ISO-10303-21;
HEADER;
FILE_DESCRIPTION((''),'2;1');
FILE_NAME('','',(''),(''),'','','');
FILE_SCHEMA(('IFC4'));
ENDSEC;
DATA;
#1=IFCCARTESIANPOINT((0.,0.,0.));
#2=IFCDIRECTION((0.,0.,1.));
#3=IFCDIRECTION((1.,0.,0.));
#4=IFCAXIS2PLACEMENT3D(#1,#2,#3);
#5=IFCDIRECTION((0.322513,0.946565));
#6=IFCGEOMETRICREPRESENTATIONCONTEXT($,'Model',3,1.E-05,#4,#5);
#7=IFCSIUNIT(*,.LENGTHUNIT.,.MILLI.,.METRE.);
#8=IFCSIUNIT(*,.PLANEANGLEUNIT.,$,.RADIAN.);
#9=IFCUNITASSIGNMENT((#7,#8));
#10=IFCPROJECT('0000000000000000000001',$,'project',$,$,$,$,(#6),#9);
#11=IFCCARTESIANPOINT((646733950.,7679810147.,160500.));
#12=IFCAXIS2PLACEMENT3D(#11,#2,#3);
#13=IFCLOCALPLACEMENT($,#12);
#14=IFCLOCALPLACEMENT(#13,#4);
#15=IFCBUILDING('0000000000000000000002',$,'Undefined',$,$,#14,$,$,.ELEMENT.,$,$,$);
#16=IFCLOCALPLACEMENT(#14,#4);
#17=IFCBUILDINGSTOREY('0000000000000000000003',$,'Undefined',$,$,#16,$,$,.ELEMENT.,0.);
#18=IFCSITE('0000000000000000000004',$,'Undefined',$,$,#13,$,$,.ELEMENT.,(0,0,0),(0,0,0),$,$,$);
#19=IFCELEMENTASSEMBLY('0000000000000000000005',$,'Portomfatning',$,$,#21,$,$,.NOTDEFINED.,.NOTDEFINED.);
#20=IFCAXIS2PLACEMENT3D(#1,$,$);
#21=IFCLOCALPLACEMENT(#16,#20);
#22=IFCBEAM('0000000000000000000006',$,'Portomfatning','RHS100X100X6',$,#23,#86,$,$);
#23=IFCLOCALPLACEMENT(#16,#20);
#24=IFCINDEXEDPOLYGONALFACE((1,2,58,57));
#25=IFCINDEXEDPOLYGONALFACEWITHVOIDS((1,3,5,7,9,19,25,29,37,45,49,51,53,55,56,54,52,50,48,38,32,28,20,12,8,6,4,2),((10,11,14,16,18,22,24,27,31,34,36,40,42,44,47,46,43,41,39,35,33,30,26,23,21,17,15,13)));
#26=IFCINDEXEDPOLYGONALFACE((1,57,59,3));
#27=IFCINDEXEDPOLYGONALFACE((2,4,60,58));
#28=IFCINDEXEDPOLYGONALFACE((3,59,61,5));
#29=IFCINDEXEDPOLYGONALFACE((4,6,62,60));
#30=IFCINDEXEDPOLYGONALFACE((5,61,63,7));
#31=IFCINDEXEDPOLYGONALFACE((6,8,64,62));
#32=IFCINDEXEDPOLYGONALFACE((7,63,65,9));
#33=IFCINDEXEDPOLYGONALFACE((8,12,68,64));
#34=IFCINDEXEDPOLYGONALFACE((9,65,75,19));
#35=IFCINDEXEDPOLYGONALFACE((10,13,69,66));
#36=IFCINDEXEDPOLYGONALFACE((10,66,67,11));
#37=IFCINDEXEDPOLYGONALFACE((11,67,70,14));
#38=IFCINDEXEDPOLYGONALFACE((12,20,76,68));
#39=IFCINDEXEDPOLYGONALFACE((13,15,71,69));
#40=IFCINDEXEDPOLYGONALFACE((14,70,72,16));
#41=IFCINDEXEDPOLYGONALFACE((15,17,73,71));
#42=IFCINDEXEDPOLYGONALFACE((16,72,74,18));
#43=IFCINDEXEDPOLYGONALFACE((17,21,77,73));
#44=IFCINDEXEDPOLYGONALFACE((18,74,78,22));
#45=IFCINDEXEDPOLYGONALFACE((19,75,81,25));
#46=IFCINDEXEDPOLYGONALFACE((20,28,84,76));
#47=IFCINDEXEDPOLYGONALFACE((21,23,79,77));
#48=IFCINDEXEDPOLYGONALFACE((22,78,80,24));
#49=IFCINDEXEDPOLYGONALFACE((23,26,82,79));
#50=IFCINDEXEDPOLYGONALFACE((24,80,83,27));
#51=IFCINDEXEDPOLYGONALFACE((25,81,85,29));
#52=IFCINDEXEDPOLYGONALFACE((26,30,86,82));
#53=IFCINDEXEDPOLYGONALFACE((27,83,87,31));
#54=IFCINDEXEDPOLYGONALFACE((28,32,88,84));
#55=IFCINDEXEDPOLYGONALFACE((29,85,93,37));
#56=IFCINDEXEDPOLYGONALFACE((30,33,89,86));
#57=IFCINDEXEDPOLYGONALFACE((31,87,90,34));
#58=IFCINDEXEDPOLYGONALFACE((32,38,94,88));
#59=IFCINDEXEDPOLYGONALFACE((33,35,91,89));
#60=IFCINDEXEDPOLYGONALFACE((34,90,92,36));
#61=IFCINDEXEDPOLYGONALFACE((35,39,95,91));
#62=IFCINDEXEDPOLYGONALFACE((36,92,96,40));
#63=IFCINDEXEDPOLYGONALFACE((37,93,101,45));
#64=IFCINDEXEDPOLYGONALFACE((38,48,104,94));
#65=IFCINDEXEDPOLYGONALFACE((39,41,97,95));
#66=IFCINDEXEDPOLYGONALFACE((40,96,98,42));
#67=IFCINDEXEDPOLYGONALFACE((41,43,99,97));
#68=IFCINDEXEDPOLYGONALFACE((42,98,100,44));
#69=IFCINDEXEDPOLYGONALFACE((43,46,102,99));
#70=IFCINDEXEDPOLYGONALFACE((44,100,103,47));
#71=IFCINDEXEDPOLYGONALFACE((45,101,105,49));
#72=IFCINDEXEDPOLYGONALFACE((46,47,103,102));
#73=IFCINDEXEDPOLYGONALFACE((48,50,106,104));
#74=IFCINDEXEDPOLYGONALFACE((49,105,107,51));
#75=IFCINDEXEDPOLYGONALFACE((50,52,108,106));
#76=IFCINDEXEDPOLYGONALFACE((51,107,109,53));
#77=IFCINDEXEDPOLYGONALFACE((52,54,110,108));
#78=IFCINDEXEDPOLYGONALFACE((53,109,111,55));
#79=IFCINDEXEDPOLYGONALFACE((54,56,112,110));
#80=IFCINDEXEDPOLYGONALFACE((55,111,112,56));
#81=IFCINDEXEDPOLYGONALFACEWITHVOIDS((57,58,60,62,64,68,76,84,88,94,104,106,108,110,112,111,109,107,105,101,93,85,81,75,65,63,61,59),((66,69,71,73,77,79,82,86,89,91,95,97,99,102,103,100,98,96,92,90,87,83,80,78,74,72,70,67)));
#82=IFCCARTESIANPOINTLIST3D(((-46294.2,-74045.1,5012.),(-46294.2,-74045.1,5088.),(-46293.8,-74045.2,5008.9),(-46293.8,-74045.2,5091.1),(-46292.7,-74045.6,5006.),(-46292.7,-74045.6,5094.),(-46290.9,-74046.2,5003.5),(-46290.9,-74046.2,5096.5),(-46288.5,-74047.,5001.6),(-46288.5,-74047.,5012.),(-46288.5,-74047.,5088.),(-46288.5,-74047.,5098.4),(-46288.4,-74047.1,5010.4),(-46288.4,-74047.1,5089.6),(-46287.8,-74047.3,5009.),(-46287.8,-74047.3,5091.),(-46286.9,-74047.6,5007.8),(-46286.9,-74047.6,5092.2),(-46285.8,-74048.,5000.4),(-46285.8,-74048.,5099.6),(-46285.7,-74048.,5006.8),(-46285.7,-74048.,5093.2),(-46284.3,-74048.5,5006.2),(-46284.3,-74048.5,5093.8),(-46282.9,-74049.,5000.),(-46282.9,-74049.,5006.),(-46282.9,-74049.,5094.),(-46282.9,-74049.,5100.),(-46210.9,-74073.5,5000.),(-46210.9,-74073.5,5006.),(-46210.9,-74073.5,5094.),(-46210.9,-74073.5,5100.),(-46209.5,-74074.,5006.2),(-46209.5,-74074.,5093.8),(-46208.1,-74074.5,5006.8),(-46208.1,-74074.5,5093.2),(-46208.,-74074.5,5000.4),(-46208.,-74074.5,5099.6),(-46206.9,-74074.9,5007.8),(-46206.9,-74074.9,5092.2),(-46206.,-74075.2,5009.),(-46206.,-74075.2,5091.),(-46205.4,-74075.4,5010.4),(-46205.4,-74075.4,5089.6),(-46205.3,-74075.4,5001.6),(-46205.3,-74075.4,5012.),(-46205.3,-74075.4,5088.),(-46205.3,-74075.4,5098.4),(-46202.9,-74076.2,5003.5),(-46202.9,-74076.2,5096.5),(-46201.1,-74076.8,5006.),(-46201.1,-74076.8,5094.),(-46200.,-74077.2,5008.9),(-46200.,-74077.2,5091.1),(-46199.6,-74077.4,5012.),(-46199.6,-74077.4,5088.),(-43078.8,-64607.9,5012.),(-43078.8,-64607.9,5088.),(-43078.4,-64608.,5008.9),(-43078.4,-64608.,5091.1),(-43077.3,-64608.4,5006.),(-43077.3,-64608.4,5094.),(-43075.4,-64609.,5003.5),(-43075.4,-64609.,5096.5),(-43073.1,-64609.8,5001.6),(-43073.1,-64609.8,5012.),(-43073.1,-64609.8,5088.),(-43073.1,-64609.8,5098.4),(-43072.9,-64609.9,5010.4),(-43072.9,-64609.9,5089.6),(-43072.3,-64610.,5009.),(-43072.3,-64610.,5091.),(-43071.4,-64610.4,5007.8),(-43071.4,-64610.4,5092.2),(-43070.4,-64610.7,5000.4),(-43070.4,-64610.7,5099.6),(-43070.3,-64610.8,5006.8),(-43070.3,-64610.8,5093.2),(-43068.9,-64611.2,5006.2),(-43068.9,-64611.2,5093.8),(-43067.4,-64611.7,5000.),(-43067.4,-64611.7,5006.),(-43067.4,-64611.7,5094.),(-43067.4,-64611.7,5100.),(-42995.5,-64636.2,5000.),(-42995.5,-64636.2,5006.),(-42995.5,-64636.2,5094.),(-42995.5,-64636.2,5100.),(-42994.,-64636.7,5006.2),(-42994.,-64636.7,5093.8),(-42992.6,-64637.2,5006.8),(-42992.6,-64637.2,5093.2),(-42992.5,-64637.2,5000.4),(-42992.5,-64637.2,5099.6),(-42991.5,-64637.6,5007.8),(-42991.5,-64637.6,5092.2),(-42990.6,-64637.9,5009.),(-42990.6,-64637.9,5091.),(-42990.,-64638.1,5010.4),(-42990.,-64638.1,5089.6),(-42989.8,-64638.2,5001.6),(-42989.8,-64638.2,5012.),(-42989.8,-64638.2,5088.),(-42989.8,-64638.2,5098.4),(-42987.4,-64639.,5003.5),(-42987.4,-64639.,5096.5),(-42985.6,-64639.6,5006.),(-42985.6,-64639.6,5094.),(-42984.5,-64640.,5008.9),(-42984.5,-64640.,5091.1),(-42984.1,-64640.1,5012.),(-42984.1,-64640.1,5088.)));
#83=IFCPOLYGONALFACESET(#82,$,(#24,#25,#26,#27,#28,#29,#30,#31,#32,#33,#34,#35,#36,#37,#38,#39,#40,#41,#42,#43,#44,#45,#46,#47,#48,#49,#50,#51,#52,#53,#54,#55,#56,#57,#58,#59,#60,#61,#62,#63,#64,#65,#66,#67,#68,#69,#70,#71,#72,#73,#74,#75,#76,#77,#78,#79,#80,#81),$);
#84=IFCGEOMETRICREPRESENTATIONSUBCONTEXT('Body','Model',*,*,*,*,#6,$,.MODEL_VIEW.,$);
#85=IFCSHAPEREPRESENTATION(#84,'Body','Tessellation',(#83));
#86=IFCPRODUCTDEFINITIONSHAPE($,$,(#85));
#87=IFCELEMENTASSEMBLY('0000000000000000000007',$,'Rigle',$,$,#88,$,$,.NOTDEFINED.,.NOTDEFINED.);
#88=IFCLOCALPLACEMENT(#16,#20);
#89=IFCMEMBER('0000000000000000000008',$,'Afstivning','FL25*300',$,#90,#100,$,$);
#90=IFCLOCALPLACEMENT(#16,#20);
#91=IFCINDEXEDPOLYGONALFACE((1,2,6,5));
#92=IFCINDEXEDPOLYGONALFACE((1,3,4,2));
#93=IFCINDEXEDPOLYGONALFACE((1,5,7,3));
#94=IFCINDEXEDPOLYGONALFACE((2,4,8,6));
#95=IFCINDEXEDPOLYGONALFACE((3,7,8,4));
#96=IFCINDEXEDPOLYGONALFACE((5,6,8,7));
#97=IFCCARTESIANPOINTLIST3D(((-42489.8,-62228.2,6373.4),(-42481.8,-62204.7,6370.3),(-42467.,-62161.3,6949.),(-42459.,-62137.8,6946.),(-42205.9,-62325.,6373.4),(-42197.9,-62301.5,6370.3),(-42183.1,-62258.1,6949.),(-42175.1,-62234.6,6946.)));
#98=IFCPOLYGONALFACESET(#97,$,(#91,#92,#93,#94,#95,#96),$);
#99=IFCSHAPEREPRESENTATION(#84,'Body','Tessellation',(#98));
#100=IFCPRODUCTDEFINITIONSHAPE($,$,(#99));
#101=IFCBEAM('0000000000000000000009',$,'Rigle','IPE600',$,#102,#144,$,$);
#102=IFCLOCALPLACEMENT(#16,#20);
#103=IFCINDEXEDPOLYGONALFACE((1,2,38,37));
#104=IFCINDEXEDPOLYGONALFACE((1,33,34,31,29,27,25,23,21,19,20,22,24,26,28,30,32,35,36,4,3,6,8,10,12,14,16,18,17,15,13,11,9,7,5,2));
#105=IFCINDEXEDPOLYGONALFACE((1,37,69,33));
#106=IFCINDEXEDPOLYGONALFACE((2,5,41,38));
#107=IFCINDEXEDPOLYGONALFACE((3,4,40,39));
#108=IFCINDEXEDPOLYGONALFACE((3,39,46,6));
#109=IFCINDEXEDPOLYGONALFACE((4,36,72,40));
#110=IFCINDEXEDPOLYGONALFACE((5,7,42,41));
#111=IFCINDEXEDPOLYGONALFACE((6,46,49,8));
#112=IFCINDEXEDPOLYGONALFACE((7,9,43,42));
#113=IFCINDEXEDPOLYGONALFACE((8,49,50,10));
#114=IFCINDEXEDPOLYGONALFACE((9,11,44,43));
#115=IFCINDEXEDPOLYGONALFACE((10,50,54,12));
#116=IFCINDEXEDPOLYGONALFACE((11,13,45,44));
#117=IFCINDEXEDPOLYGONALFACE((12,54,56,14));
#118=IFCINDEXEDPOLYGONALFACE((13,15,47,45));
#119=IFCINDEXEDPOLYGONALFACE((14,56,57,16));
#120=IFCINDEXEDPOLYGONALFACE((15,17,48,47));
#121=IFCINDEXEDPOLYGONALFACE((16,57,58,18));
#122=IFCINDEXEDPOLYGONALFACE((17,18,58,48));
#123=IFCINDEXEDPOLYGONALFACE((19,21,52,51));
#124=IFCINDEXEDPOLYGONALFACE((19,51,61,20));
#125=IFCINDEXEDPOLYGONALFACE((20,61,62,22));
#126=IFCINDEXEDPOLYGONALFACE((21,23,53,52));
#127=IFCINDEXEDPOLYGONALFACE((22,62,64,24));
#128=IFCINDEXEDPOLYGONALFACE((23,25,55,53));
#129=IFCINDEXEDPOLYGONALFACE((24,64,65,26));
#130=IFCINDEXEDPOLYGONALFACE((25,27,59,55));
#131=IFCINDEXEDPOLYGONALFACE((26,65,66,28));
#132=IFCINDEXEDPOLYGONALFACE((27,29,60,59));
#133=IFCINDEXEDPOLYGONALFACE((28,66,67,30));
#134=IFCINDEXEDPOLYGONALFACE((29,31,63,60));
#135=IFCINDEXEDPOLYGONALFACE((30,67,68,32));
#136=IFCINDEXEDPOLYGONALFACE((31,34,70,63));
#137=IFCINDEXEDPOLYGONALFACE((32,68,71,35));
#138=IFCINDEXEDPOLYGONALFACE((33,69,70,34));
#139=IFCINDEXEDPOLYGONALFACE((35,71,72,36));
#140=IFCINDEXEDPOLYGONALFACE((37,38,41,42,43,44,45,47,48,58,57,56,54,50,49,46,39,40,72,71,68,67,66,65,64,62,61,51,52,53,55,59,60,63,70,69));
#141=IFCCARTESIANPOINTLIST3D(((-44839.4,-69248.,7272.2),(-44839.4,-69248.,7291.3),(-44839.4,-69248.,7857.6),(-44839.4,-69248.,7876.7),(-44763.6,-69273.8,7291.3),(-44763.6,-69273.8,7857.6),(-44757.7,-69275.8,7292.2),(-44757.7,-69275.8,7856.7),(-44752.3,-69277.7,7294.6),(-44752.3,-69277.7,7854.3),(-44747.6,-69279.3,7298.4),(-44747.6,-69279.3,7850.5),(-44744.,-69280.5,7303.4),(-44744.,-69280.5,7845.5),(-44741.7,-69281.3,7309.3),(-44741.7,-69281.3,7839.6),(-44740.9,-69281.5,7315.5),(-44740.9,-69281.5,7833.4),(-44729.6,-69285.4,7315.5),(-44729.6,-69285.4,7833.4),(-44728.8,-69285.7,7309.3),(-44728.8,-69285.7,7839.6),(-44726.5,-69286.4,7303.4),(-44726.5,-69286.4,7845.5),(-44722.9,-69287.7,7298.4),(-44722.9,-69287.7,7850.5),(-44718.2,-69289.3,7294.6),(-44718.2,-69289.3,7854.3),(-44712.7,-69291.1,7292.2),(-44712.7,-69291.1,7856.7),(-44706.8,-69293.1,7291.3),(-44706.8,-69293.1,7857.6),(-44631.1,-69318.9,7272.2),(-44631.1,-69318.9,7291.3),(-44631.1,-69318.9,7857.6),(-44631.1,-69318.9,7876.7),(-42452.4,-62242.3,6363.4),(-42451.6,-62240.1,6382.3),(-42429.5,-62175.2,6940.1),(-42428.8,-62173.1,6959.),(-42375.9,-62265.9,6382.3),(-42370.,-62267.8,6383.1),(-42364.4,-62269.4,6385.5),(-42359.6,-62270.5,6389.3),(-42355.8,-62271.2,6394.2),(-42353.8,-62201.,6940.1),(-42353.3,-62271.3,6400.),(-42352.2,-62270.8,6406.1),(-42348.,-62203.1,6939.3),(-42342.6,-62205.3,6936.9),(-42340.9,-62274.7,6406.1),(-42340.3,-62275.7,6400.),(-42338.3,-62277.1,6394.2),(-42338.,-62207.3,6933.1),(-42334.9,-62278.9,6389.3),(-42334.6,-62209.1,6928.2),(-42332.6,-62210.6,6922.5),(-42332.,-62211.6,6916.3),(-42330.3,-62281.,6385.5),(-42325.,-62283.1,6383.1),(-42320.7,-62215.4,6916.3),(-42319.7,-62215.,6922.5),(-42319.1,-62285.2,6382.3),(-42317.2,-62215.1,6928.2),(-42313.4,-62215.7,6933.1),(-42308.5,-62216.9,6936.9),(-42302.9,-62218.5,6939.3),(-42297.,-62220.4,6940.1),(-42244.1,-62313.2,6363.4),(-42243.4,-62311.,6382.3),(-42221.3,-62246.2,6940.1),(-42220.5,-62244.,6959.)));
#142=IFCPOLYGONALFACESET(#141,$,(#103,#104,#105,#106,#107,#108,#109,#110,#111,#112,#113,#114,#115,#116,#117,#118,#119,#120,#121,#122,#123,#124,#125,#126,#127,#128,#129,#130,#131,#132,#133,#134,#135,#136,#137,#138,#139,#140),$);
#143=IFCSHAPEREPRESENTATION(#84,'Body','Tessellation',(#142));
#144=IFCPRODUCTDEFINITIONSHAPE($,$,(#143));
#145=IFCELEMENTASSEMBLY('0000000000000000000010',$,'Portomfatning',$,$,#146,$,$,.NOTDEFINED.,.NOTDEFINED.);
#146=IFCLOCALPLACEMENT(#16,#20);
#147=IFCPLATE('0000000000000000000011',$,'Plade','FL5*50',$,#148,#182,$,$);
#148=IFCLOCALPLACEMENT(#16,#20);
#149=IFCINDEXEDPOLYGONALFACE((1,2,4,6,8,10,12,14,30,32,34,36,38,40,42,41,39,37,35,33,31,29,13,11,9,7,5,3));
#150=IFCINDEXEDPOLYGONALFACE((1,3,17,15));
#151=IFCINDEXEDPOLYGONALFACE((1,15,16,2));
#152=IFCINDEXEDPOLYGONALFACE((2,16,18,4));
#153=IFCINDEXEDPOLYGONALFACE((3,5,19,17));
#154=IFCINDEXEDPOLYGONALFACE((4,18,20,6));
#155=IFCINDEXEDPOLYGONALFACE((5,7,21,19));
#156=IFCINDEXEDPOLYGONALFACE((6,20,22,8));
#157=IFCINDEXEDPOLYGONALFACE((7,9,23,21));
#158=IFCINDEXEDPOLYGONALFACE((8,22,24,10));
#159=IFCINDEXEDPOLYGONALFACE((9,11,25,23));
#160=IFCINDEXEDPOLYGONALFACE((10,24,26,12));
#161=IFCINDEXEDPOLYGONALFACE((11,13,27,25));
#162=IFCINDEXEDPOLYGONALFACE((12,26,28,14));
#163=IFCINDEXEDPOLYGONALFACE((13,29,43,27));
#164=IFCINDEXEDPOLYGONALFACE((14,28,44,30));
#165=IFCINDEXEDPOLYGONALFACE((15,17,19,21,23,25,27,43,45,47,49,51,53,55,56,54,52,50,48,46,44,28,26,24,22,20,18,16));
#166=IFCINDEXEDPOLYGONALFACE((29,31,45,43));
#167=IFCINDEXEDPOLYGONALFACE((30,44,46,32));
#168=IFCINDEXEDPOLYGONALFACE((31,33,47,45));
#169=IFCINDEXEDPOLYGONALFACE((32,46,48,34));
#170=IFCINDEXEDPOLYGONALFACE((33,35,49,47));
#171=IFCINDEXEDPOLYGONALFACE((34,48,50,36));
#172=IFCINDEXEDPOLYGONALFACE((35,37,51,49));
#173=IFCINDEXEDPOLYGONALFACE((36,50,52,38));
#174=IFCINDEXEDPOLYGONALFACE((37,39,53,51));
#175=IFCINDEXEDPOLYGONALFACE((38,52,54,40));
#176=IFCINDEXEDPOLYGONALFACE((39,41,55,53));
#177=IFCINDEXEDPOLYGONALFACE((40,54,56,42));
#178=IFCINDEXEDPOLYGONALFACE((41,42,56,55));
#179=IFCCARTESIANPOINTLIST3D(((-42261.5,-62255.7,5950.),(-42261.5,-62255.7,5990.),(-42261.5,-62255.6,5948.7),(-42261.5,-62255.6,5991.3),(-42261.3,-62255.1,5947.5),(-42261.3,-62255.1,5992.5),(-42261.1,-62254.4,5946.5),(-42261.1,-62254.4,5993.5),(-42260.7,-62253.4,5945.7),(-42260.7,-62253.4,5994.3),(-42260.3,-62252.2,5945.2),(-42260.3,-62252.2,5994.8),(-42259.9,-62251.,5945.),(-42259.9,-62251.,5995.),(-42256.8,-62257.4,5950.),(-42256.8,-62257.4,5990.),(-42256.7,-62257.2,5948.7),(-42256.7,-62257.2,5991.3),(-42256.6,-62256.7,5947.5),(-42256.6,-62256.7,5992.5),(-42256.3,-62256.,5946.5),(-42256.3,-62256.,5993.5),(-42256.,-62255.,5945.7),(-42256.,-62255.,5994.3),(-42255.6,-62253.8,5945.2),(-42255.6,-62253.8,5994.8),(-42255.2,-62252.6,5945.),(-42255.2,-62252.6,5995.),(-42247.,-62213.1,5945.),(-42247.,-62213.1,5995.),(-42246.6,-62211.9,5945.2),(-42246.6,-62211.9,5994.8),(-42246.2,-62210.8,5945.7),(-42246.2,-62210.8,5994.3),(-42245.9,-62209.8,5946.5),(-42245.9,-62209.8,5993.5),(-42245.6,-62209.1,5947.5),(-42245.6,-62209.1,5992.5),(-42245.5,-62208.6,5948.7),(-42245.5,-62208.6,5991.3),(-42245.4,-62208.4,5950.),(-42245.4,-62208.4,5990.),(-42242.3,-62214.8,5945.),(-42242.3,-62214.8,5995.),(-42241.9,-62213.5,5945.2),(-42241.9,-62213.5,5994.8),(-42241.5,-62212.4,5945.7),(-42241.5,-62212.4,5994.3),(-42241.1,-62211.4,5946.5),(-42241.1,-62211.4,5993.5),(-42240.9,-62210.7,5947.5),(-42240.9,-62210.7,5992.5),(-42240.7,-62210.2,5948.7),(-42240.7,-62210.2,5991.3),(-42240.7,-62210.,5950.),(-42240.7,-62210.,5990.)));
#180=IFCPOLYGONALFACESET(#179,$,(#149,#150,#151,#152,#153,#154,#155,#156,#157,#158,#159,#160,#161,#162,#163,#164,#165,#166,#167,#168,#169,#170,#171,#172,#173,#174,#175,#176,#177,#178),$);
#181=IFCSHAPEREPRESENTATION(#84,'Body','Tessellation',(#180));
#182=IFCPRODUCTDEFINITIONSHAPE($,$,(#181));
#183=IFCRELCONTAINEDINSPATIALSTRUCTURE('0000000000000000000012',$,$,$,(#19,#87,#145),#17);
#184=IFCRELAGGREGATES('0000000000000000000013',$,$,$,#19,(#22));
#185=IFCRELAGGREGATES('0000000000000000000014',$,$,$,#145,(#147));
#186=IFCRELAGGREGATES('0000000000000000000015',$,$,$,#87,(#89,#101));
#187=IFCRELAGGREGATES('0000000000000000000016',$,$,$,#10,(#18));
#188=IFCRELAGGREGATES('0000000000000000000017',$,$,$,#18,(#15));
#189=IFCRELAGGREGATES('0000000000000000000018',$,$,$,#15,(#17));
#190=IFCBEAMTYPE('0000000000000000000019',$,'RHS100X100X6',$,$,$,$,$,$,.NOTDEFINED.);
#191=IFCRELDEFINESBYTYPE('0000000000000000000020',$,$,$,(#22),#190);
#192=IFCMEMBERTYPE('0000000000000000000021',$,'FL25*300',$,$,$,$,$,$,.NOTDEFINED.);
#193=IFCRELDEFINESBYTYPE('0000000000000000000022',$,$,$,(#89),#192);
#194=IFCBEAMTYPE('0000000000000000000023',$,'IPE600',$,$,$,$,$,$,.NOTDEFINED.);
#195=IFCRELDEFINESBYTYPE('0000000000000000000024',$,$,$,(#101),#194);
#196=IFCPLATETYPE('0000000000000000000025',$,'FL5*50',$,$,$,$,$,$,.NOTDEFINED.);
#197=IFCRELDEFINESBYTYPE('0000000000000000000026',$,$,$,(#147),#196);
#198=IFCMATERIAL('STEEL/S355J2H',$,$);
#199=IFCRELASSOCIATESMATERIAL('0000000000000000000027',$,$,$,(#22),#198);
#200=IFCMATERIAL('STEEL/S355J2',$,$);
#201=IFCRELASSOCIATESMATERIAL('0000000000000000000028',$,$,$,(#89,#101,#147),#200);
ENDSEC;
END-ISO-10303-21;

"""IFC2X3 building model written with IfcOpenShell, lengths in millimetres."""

from ifc_helpers import new_model, si_unit, direction, frame, frame_2d, origin_with_axes, origin_2d_with_axis, place, context, subcontext, project, spatial, polyline, circle_curve, parameter, trimmed, segment, composite_curve, rectangle, hollow_rectangle, i_section, outline, extrude, clip, halfspace, material, type_object, element, aggregate, save


model = new_model("IFC2X3")

# Units and contexts
model_context = context("Model", 3, precision=1e-05, world=origin_with_axes(), true_north=direction((0.322513, 0.946565)))
body_context = subcontext(model_context, "Body", "Model", "MODEL_VIEW")
ifc_project = project(units=[si_unit("LENGTHUNIT", "METRE", prefix="MILLI"), si_unit("PLANEANGLEUNIT", "RADIAN")], contexts=[model_context])

# Site, building, storey
site_placement = place(None, frame((646733950.0, 7679810147.0, 160500.0), z_axis=(0.0, 0.0, 1.0), x_axis=(1.0, 0.0, 0.0)))
site = spatial("IfcSite", under=ifc_project, at=site_placement, Name="Undefined", CompositionType="ELEMENT", RefLatitude=(0, 0, 0), RefLongitude=(0, 0, 0))
building_placement = place(site_placement, origin_with_axes())
building = spatial("IfcBuilding", under=site, at=building_placement, Name="Undefined", CompositionType="ELEMENT")
storey_placement = place(building_placement, origin_with_axes())
storey = spatial("IfcBuildingStorey", under=building, at=storey_placement, Name="Undefined", CompositionType="ELEMENT", Elevation=0.0)

# Element assembly, beam
assembly_1_placement = place(storey_placement, origin_with_axes())
assembly_1 = element("IfcElementAssembly", 1, at=assembly_1_placement, inside=storey, Name="Portomfatning", AssemblyPlace="NOTDEFINED", PredefinedType="NOTDEFINED")
ifc_material_1 = material(Name="STEEL/S355J2H")
beam_type_1 = type_object("IfcBeamType", Name="RHS100X100X6", PredefinedType="NOTDEFINED")
beam_1_placement = place(assembly_1_placement, frame((-43026.6, -64609.8, 5050.0), z_axis=(-0.946565, 0.322513, 0.0), x_axis=(-0.322513, -0.946565, 0.0)))
beam_1 = element("IfcBeam", 2, at=beam_1_placement, type_object=beam_type_1, material=ifc_material_1, Name="Portomfatning", Description="RHS100X100X6", context=body_context, shape_type="Clipping", body=[
    clip(clip(extrude(hollow_rectangle(XDim=100.0, YDim=100.0, WallThickness=6.0, InnerFilletRadius=6.0, OuterFilletRadius=12.0, at=origin_2d_with_axis()), frame((10046.7, 0.0, 0.0), z_axis=(-1.0, 0.0, 0.0), x_axis=(0.0, -1.0, 0.0)), (0.0, 0.0, 1.0), 10093.3), halfspace(frame((9985.0, 0.0, -50.0), z_axis=(-1.0, 0.0, 0.0), x_axis=(0.0, 1.0, 0.0)), True)), halfspace(frame((15.0, 0.0, -50.0), z_axis=(1.0, 0.0, 0.0), x_axis=(0.0, -1.0, 0.0)), True)),
])
aggregate(assembly_1, [beam_1])
ifc_material_2 = material(Name="STEEL/S355J2")

# Element assembly, member, beam
assembly_2_placement = place(storey_placement, origin_with_axes())
assembly_2 = element("IfcElementAssembly", 3, at=assembly_2_placement, inside=storey, Name="Rigle", AssemblyPlace="NOTDEFINED", PredefinedType="NOTDEFINED")
member_type_1 = type_object("IfcMemberType", Name="FL25*300", PredefinedType="NOTDEFINED")
member_1_placement = place(assembly_2_placement, frame((-42321.1, -62197.9, 6947.5), z_axis=(-0.946565, 0.322513, 0.0), x_axis=(-0.039304, -0.115357, -0.992546)))
member_1 = element("IfcMember", 4, at=member_1_placement, type_object=member_type_1, material=ifc_material_2, Name="Afstivning", Description="FL25*300", context=body_context, shape_type="SweptSolid", body=[
    extrude(rectangle(XDim=25.0, YDim=300.0, at=origin_2d_with_axis()), frame((580.0, 0.0, 0.0), z_axis=(-1.0, 0.0, 0.0), x_axis=(0.0, -1.0, 0.0)), (0.0, 0.0, 1.0), 580.0),
])
beam_type_2 = type_object("IfcBeamType", Name="IPE600", PredefinedType="NOTDEFINED")
beam_2_placement = place(assembly_2_placement, frame((-42332.5, -62231.4, 6659.7), z_axis=(0.039304, 0.115357, 0.992546), x_axis=(-0.320109, -0.93951, 0.121869)))
beam_2 = element("IfcBeam", 5, at=beam_2_placement, type_object=beam_type_2, material=ifc_material_2, Name="Rigle", Description="IPE600", context=body_context, shape_type="Clipping", body=[
    clip(clip(extrude(i_section(OverallWidth=220.0, OverallDepth=600.0, WebThickness=12.0, FlangeThickness=19.0, FilletRadius=24.0, at=origin_2d_with_axis()), frame((7751.3, 0.0, 0.0), z_axis=(-1.0, 0.0, 0.0), x_axis=(0.0, -1.0, 0.0)), (0.0, 0.0, 1.0), 7983.9), halfspace(frame((7543.3, 0.0, 303.0), z_axis=(0.992546, 0.0, -0.121869), x_axis=(0.0, 1.0, 0.0)), False)), halfspace(frame((12.5, 0.0, 0.0), z_axis=(-1.0, 0.0, 0.0), x_axis=(0.0, 1.0, 0.0)), False)),
])

# Element assembly, plate
assembly_3_placement = place(storey_placement, origin_with_axes())
assembly_3 = element("IfcElementAssembly", 6, at=assembly_3_placement, inside=storey, Name="Portomfatning", AssemblyPlace="NOTDEFINED", PredefinedType="NOTDEFINED")
plate_type_1 = type_object("IfcPlateType", Name="FL5*50", PredefinedType="NOTDEFINED")
plate_1_placement = place(assembly_3_placement, frame((-42259.2, -62256.6, 5995.0), z_axis=(-0.946565, 0.322513, 0.0), x_axis=(0.322513, 0.946565, 0.0)))
plate_1 = element("IfcPlate", 7, at=plate_1_placement, type_object=plate_type_1, material=ifc_material_2, Name="Plade", Description="FL5*50", context=body_context, shape_type="SweptSolid", body=[
    extrude(outline(composite_curve([segment(trimmed(circle_curve(frame_2d((5.0, 5.0), x_axis=(-1.0, 0.0)), 5.0), [parameter(0.0)], [parameter(1.570796)], True, "PARAMETER"), True, "CONTINUOUS"), segment(polyline([(5.0, 0.0), (45.0, 0.0)]), True, "CONTINUOUS"), segment(trimmed(circle_curve(frame_2d((45.0, 5.0), x_axis=(0.0, -1.0)), 5.0), [parameter(0.0)], [parameter(1.570796)], True, "PARAMETER"), True, "CONTINUOUS"), segment(polyline([(50.0, 5.0), (50.0, 45.0)]), True, "CONTINUOUS"), segment(trimmed(circle_curve(frame_2d((45.0, 45.0), x_axis=(1.0, 0.0)), 5.0), [parameter(0.0)], [parameter(1.570796)], True, "PARAMETER"), True, "CONTINUOUS"), segment(polyline([(45.0, 50.0), (5.0, 50.0)]), True, "CONTINUOUS"), segment(trimmed(circle_curve(frame_2d((5.0, 45.0), x_axis=(0.0, 1.0)), 5.0), [parameter(0.0)], [parameter(1.570796)], True, "PARAMETER"), True, "CONTINUOUS"), segment(polyline([(0.0, 45.0), (0.0, 5.0)]), True, "CONTINUOUS")], self_intersect=True)), frame((0.0, 0.0, -2.5), z_axis=(0.0, 0.0, 1.0), x_axis=(1.0, 0.0, 0.0)), (0.0, 0.0, 1.0), 5.0),
])
aggregate(assembly_3, [plate_1])

aggregate(assembly_2, [member_1, beam_2])

save(model, "model.ifc")
